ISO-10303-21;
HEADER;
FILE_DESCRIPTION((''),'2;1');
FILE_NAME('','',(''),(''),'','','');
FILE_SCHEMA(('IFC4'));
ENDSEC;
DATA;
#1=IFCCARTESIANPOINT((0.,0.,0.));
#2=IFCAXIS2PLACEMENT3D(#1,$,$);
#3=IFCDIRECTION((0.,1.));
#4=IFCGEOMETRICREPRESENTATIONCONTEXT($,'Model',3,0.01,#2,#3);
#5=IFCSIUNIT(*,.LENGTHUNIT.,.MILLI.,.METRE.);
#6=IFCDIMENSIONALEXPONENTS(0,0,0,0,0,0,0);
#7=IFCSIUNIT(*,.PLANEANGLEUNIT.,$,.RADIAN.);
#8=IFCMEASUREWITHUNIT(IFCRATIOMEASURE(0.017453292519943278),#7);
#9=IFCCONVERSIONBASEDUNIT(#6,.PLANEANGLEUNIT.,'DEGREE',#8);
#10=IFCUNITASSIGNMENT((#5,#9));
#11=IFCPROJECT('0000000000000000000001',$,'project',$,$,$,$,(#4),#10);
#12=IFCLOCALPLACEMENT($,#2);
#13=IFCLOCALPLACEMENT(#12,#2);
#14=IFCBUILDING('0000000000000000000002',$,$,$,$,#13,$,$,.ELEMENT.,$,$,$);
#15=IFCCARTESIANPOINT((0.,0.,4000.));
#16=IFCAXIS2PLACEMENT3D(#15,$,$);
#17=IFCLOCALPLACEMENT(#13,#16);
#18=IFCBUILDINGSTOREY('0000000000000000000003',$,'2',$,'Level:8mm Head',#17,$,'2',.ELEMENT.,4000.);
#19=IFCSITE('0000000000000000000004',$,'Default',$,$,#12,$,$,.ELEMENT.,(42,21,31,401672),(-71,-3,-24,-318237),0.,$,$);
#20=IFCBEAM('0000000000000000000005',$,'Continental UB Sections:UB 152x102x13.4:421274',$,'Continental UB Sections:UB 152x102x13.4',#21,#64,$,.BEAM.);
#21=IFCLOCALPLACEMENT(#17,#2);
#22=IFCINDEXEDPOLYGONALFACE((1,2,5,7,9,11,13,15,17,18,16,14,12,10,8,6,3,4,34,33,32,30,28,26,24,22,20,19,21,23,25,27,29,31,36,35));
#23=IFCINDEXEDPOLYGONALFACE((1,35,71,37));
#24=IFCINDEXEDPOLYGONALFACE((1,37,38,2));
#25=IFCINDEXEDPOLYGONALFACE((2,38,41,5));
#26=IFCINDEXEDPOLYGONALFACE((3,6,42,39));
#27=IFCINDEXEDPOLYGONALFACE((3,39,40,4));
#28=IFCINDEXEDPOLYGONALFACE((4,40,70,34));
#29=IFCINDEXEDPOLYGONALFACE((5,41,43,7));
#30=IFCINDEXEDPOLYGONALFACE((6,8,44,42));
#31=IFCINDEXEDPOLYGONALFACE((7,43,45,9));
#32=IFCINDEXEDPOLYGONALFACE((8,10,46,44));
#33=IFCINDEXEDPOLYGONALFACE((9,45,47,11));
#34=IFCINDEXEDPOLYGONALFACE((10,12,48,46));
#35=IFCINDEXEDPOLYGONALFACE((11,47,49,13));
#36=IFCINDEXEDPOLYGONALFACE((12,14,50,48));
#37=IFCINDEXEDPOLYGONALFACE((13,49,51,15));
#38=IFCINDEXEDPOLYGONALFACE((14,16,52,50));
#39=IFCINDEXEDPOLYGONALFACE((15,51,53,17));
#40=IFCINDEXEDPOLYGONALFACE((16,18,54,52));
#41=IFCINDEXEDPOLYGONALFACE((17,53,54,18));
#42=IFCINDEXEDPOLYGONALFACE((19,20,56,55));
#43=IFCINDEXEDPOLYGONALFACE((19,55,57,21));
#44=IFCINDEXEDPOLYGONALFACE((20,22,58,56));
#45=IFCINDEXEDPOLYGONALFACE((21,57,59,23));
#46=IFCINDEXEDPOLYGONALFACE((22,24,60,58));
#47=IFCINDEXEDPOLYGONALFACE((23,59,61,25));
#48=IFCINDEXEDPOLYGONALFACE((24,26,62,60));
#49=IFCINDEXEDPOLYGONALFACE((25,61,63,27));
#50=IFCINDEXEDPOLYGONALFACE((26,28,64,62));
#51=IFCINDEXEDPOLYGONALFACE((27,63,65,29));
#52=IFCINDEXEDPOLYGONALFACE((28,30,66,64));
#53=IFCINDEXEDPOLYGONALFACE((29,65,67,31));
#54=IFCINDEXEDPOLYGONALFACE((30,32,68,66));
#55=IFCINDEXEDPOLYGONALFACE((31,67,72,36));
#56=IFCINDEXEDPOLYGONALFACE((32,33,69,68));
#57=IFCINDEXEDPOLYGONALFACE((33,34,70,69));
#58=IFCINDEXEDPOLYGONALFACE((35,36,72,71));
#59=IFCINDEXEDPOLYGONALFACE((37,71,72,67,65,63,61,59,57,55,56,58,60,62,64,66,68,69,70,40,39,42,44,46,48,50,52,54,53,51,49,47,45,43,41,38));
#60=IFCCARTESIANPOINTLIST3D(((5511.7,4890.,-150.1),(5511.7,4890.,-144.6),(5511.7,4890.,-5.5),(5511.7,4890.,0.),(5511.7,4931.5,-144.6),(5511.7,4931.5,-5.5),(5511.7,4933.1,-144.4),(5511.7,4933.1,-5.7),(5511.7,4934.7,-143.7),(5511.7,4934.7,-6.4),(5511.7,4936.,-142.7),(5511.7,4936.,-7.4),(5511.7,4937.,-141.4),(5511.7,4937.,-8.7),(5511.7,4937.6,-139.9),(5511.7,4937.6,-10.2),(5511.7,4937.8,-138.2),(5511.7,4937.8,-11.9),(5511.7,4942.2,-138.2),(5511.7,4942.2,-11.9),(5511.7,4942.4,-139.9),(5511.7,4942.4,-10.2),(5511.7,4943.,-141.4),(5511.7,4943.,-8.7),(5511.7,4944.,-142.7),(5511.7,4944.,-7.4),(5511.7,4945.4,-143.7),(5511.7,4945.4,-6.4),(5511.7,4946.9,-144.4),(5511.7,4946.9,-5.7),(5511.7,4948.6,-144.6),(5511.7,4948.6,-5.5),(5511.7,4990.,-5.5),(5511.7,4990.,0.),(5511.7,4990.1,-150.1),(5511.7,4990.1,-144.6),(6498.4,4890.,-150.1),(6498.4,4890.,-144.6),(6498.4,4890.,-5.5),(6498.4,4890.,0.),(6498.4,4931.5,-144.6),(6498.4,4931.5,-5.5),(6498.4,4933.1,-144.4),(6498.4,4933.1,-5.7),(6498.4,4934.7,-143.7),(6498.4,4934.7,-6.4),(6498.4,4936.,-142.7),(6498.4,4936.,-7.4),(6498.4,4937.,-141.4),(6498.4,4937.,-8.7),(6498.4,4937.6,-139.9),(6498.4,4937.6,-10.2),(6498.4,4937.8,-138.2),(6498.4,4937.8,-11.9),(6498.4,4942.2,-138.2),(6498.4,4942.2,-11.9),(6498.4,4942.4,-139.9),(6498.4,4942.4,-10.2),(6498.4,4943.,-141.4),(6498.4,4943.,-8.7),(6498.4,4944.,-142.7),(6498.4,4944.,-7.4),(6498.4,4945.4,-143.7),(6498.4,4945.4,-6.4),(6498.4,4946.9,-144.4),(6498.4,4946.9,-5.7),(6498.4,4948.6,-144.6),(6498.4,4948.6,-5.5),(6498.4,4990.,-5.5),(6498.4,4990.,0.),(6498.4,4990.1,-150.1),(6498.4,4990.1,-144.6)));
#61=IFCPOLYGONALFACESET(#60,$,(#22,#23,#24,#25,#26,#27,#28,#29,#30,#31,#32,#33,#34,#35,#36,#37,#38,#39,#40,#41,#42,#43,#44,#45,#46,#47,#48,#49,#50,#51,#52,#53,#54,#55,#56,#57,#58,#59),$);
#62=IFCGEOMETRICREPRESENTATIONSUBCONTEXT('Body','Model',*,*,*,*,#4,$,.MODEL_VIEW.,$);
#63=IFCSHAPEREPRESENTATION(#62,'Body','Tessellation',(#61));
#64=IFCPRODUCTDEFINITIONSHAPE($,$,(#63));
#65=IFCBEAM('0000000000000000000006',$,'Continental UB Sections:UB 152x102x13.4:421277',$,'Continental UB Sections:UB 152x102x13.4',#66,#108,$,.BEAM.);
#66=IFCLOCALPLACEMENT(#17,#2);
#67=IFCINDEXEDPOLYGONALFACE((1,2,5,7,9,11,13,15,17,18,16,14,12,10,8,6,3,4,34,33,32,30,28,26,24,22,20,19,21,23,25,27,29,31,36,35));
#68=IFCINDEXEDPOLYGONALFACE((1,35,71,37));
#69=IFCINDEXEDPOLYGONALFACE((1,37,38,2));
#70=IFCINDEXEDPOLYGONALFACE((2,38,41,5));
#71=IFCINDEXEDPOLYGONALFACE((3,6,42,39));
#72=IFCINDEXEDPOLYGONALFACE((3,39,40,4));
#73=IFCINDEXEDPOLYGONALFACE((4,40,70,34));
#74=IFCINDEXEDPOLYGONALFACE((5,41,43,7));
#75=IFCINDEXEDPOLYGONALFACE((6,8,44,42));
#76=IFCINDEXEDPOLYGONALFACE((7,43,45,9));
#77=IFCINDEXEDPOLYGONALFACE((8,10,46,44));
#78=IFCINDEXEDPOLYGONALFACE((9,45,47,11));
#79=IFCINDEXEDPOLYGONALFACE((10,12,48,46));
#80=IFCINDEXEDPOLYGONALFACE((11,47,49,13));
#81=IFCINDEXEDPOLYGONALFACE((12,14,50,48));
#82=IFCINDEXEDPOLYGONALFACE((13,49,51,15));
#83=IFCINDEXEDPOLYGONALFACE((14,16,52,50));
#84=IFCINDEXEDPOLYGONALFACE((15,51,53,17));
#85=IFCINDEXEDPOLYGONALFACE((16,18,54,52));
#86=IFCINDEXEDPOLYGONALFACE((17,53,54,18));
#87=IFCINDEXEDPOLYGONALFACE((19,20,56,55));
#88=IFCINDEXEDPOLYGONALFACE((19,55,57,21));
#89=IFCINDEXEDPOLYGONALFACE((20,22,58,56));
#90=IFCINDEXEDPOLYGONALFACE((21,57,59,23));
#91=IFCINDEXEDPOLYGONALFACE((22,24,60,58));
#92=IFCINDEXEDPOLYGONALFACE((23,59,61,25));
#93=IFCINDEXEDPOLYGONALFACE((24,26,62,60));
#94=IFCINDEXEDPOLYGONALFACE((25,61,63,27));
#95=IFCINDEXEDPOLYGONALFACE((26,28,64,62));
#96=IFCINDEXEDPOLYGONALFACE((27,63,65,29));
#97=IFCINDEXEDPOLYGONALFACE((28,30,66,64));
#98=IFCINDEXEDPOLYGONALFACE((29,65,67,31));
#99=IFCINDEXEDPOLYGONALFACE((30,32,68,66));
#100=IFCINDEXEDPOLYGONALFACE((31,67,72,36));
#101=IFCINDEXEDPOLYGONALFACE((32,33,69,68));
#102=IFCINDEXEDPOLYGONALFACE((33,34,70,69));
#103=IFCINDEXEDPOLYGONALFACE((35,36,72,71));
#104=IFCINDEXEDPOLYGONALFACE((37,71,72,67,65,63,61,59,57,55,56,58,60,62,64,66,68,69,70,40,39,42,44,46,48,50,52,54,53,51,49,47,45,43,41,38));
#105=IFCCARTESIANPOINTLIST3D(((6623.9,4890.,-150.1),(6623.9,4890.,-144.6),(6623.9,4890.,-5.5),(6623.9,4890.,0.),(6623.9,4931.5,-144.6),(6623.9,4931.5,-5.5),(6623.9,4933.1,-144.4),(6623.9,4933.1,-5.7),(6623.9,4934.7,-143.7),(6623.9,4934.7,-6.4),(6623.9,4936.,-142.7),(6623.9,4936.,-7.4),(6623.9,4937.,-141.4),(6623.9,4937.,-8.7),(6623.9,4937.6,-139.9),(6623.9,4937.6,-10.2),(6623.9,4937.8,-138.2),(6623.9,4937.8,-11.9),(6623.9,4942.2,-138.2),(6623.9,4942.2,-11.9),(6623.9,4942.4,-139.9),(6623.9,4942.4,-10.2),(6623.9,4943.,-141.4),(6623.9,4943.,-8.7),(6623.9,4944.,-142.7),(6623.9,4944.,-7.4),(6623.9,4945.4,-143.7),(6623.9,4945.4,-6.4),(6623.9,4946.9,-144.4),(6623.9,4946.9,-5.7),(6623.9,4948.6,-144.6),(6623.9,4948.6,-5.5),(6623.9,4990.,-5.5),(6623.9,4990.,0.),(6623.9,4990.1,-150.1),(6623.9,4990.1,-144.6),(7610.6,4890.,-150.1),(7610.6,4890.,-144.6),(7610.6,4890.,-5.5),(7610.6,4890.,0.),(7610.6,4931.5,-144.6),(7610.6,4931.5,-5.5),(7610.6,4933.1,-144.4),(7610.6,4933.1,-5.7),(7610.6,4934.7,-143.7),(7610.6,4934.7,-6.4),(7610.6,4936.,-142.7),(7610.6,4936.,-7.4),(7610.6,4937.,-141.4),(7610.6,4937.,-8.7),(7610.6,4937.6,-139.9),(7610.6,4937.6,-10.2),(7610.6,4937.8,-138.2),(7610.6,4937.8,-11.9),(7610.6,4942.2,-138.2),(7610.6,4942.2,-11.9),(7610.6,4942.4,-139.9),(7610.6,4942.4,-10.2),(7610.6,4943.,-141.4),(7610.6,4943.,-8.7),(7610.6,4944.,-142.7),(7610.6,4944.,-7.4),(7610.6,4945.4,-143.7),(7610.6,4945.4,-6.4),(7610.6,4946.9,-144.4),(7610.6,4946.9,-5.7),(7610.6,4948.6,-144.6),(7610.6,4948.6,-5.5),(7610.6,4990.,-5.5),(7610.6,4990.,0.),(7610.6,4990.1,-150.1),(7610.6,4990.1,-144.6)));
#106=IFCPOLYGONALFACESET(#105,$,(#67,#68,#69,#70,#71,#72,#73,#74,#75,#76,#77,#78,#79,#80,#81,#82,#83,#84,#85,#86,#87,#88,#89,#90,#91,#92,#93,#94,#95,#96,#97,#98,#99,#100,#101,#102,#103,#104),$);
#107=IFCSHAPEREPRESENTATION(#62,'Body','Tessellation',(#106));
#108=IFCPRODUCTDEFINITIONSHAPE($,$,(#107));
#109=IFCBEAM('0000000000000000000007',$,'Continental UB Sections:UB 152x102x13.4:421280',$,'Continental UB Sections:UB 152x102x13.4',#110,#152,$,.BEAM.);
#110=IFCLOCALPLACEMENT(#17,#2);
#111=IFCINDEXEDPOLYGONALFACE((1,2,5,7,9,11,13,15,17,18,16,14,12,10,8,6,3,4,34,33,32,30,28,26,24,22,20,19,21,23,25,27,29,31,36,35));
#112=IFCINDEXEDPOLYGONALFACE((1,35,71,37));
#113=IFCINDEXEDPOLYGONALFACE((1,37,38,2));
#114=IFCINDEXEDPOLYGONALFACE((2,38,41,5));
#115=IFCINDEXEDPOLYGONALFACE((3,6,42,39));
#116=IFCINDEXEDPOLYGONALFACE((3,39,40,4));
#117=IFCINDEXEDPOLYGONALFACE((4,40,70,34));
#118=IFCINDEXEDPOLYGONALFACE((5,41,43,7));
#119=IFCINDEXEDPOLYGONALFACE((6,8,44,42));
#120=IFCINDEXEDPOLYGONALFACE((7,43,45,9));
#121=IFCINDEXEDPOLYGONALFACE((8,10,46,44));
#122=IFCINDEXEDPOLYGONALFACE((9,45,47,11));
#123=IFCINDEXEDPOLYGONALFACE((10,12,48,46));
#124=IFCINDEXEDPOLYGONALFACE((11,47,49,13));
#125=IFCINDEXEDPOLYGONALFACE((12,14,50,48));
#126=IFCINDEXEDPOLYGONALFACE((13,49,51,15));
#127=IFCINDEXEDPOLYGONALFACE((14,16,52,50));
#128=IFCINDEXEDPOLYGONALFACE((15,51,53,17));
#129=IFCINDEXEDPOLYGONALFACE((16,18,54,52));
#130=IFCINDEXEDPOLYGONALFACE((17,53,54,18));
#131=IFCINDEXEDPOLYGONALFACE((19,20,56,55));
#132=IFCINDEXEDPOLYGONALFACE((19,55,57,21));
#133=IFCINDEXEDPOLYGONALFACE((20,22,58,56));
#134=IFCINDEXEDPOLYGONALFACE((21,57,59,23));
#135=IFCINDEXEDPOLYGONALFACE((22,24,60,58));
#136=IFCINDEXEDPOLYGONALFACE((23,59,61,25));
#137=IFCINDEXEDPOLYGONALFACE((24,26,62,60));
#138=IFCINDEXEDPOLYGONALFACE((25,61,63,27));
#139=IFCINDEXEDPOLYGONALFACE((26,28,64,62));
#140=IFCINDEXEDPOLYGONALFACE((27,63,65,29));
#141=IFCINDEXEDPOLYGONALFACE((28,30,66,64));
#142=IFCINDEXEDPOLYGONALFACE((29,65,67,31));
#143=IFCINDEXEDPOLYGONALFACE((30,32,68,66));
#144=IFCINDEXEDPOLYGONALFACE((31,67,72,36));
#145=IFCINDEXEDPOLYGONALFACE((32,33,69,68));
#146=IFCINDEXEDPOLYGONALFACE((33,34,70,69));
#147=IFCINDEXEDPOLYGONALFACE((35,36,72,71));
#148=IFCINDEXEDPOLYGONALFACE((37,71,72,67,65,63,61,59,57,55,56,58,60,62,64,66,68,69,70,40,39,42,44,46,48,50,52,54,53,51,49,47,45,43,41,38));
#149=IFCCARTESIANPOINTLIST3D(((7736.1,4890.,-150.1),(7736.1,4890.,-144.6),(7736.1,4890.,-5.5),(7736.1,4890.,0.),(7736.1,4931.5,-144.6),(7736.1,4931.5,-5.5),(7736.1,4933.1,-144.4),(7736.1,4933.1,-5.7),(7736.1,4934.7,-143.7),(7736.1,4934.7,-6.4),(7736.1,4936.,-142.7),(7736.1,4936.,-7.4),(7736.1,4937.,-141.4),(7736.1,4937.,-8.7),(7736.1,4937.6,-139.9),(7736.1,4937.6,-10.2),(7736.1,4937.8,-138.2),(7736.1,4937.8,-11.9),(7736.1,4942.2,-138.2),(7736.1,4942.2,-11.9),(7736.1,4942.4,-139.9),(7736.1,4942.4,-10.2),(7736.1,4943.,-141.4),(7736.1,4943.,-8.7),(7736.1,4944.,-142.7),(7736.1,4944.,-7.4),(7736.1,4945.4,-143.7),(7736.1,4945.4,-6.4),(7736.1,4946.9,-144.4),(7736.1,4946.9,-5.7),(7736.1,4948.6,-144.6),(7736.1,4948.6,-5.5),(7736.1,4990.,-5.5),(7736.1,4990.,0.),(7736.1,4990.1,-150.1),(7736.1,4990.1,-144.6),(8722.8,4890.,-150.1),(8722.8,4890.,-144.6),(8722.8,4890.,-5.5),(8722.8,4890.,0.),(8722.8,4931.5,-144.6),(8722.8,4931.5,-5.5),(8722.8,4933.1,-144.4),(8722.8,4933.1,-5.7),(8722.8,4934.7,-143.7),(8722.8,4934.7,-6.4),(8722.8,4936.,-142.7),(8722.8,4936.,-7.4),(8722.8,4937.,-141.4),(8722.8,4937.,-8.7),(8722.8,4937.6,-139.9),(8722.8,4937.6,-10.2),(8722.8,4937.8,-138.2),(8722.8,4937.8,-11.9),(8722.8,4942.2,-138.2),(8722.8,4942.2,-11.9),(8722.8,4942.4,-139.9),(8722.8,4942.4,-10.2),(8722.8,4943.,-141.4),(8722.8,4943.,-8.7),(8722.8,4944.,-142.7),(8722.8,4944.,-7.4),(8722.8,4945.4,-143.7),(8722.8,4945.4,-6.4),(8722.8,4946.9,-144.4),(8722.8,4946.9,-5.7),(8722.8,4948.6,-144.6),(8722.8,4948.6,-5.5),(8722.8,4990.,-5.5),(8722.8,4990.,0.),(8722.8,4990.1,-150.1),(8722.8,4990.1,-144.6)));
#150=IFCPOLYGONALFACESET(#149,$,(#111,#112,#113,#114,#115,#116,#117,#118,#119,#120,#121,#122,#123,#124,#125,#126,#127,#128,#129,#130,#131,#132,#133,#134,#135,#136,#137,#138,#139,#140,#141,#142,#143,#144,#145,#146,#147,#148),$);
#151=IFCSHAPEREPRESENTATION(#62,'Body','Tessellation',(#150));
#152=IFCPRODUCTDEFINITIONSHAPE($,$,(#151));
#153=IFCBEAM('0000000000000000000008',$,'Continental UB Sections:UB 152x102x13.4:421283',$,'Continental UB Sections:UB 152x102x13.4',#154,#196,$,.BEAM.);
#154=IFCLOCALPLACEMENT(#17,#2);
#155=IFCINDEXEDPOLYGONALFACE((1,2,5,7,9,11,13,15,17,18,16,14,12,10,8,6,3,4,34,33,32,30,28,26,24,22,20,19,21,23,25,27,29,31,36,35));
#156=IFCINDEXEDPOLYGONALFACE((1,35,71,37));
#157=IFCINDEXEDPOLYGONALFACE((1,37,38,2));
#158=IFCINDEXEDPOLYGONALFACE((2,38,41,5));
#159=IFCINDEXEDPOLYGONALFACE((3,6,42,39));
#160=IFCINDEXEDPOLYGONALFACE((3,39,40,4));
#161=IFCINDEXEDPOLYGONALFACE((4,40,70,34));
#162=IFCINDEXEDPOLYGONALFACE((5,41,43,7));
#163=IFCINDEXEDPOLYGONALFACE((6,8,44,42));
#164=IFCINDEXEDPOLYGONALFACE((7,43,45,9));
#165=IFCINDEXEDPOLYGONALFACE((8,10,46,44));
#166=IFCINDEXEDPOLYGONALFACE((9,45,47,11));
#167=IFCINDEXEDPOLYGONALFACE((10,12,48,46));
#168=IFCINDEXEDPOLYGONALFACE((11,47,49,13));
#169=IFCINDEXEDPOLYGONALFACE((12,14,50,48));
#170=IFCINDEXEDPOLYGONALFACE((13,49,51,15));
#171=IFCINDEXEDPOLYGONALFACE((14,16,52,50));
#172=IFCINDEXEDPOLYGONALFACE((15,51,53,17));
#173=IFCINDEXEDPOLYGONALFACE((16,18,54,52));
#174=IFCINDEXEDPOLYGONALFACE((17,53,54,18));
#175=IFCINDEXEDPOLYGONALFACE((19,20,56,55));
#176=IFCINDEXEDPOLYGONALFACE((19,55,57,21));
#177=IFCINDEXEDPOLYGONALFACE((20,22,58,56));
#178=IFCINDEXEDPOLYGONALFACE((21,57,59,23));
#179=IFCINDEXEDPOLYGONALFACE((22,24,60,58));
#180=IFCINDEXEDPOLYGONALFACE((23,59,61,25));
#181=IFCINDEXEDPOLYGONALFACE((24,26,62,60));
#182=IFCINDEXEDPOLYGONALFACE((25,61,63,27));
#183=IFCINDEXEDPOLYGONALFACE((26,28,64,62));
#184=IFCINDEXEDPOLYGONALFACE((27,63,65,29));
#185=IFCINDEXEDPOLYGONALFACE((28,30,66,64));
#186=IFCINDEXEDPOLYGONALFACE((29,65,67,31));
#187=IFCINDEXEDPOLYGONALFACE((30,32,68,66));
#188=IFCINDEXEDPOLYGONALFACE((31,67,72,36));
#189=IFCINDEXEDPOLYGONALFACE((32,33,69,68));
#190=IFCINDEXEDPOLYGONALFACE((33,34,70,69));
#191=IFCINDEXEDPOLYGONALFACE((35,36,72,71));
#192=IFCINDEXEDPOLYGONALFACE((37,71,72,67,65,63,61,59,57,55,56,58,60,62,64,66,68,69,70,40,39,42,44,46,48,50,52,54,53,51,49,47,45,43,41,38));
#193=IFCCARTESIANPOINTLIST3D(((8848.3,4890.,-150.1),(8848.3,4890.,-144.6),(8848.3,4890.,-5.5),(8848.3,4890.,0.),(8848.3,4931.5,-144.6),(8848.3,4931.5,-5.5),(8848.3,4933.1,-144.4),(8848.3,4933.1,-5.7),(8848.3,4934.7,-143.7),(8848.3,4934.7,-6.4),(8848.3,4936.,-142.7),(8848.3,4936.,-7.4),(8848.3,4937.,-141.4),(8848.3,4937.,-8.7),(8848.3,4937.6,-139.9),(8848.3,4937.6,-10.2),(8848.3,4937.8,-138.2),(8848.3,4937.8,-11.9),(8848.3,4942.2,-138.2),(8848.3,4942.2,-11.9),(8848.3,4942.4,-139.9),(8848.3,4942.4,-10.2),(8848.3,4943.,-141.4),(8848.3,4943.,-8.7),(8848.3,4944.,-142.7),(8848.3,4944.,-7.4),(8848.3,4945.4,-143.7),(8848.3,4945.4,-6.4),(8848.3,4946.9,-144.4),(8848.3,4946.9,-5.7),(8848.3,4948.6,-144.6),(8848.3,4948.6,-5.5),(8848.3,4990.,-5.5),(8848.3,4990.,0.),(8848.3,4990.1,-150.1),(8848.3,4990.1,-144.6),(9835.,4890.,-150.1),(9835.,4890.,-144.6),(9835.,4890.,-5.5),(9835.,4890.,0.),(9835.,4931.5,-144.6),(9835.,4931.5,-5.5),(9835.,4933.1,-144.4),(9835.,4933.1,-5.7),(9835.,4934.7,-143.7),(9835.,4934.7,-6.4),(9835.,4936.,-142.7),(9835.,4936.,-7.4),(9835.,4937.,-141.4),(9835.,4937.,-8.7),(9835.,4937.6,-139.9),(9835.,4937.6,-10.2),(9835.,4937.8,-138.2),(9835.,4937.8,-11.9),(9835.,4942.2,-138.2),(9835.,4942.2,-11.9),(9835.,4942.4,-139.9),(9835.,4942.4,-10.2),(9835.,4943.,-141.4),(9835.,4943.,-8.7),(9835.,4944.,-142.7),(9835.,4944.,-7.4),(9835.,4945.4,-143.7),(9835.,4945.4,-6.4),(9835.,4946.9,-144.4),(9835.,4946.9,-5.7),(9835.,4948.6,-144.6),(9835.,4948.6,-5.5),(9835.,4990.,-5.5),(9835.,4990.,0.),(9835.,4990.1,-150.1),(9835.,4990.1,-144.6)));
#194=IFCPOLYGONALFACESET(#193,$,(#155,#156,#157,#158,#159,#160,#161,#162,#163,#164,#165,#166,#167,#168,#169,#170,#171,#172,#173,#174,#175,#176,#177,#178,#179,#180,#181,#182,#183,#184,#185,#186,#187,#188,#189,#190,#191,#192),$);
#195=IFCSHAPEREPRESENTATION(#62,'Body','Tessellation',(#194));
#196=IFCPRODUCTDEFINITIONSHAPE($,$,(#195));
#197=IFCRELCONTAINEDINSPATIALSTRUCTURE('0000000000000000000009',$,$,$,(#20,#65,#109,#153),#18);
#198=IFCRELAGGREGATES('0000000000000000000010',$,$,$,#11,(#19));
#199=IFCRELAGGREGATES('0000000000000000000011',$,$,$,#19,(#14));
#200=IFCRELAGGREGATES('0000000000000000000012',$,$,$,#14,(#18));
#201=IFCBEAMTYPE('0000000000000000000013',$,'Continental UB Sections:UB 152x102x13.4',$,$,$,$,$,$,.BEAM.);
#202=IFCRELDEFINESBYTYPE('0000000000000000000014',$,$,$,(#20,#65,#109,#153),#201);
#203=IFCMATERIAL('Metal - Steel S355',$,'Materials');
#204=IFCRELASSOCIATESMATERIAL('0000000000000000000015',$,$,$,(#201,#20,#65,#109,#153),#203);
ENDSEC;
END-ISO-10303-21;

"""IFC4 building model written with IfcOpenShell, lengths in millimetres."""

from ifc_helpers import new_model, entity, si_unit, converted_unit, direction, frame, origin, place, context, subcontext, project, spatial, line, arc, indexed_curve, outline, extrude, source, transform, mapped, material, type_object, type_shapes, element, save


model = new_model("IFC4")

# Units and contexts
model_context = context("Model", 3, precision=0.01, world=origin(), true_north=direction((0.0, 1.0)))
body_context = subcontext(model_context, "Body", "Model", "MODEL_VIEW")
ifc_project = project(units=[si_unit("LENGTHUNIT", "METRE", prefix="MILLI"), converted_unit("PLANEANGLEUNIT", "DEGREE", entity("IfcRatioMeasure", 0.017453292519943278), si_unit("PLANEANGLEUNIT", "RADIAN"), dimensions=[0, 0, 0, 0, 0, 0, 0])], contexts=[model_context])

# Site, building, storey
site_placement = place(None, origin())
site = spatial("IfcSite", under=ifc_project, at=site_placement, Name="Default", CompositionType="ELEMENT", RefLatitude=(42, 21, 31, 401672), RefLongitude=(-71, -3, -24, -318237), RefElevation=0.0)
building_placement = place(site_placement, origin())
building = spatial("IfcBuilding", under=site, at=building_placement, CompositionType="ELEMENT")
storey_placement = place(building_placement, frame((0.0, 0.0, 4000.0)))
storey = spatial("IfcBuildingStorey", under=building, at=storey_placement, Name="2", ObjectType="Level:8mm Head", LongName="2", CompositionType="ELEMENT", Elevation=4000.0)

# Beams
ifc_material = material(Name="Metal - Steel S355", Category="Materials")
beam_type_1 = type_object("IfcBeamType", Name="Continental UB Sections:UB 152x102x13.4", PredefinedType="BEAM", material=ifc_material)
shared_shape_1 = source(origin(), body_context, "Body", "SweptSolid", [
    extrude(outline(indexed_curve([(-75.0, -50.1), (-69.6, -50.1), (-69.6, -8.5), (-67.7, -4.0), (-63.2, -2.1), (63.1, -2.1), (67.7, -4.0), (69.5, -8.5), (69.5, -50.1), (75.1, -50.1), (75.1, 50.1), (69.5, 50.1), (69.5, 8.6), (67.7, 4.0), (63.1, 2.2), (-63.2, 2.2), (-67.7, 4.0), (-69.6, 8.6), (-69.6, 50.0), (-75.0, 50.0)], segments=[line(1, 2, 3), arc(3, 4, 5), line(5, 6), arc(6, 7, 8), line(8, 9, 10, 11, 12, 13), arc(13, 14, 15), line(15, 16), arc(16, 17, 18), line(18, 19, 20, 1)], self_intersect=False)), frame((-493.3, 0.0, 0.0), z_axis=(1.0, 0.0, 0.0), x_axis=(0.0, 0.0, -1.0)), (0.0, 0.0, 1.0), 986.7),
])
type_shapes(beam_type_1, [shared_shape_1])
for number, where, name in (
    (1, (6005.0, 4940.0, -75.1), "Continental UB Sections:UB 152x102x13.4:421274"),
    (2, (7117.2, 4940.0, -75.1), "Continental UB Sections:UB 152x102x13.4:421277"),
    (3, (8229.4, 4940.0, -75.1), "Continental UB Sections:UB 152x102x13.4:421280"),
    (4, (9341.7, 4940.0, -75.1), "Continental UB Sections:UB 152x102x13.4:421283"),
):
    element("IfcBeam", number, at=place(storey_placement, frame(where)), inside=storey, type_object=beam_type_1, material=ifc_material, Name=name, ObjectType="Continental UB Sections:UB 152x102x13.4", PredefinedType="BEAM", context=body_context, shape_type="MappedRepresentation", body=[
        mapped(shared_shape_1, transform((0.0, 0.0, 0.0), scale=1.0)),
    ])

save(model, "model.ifc")
